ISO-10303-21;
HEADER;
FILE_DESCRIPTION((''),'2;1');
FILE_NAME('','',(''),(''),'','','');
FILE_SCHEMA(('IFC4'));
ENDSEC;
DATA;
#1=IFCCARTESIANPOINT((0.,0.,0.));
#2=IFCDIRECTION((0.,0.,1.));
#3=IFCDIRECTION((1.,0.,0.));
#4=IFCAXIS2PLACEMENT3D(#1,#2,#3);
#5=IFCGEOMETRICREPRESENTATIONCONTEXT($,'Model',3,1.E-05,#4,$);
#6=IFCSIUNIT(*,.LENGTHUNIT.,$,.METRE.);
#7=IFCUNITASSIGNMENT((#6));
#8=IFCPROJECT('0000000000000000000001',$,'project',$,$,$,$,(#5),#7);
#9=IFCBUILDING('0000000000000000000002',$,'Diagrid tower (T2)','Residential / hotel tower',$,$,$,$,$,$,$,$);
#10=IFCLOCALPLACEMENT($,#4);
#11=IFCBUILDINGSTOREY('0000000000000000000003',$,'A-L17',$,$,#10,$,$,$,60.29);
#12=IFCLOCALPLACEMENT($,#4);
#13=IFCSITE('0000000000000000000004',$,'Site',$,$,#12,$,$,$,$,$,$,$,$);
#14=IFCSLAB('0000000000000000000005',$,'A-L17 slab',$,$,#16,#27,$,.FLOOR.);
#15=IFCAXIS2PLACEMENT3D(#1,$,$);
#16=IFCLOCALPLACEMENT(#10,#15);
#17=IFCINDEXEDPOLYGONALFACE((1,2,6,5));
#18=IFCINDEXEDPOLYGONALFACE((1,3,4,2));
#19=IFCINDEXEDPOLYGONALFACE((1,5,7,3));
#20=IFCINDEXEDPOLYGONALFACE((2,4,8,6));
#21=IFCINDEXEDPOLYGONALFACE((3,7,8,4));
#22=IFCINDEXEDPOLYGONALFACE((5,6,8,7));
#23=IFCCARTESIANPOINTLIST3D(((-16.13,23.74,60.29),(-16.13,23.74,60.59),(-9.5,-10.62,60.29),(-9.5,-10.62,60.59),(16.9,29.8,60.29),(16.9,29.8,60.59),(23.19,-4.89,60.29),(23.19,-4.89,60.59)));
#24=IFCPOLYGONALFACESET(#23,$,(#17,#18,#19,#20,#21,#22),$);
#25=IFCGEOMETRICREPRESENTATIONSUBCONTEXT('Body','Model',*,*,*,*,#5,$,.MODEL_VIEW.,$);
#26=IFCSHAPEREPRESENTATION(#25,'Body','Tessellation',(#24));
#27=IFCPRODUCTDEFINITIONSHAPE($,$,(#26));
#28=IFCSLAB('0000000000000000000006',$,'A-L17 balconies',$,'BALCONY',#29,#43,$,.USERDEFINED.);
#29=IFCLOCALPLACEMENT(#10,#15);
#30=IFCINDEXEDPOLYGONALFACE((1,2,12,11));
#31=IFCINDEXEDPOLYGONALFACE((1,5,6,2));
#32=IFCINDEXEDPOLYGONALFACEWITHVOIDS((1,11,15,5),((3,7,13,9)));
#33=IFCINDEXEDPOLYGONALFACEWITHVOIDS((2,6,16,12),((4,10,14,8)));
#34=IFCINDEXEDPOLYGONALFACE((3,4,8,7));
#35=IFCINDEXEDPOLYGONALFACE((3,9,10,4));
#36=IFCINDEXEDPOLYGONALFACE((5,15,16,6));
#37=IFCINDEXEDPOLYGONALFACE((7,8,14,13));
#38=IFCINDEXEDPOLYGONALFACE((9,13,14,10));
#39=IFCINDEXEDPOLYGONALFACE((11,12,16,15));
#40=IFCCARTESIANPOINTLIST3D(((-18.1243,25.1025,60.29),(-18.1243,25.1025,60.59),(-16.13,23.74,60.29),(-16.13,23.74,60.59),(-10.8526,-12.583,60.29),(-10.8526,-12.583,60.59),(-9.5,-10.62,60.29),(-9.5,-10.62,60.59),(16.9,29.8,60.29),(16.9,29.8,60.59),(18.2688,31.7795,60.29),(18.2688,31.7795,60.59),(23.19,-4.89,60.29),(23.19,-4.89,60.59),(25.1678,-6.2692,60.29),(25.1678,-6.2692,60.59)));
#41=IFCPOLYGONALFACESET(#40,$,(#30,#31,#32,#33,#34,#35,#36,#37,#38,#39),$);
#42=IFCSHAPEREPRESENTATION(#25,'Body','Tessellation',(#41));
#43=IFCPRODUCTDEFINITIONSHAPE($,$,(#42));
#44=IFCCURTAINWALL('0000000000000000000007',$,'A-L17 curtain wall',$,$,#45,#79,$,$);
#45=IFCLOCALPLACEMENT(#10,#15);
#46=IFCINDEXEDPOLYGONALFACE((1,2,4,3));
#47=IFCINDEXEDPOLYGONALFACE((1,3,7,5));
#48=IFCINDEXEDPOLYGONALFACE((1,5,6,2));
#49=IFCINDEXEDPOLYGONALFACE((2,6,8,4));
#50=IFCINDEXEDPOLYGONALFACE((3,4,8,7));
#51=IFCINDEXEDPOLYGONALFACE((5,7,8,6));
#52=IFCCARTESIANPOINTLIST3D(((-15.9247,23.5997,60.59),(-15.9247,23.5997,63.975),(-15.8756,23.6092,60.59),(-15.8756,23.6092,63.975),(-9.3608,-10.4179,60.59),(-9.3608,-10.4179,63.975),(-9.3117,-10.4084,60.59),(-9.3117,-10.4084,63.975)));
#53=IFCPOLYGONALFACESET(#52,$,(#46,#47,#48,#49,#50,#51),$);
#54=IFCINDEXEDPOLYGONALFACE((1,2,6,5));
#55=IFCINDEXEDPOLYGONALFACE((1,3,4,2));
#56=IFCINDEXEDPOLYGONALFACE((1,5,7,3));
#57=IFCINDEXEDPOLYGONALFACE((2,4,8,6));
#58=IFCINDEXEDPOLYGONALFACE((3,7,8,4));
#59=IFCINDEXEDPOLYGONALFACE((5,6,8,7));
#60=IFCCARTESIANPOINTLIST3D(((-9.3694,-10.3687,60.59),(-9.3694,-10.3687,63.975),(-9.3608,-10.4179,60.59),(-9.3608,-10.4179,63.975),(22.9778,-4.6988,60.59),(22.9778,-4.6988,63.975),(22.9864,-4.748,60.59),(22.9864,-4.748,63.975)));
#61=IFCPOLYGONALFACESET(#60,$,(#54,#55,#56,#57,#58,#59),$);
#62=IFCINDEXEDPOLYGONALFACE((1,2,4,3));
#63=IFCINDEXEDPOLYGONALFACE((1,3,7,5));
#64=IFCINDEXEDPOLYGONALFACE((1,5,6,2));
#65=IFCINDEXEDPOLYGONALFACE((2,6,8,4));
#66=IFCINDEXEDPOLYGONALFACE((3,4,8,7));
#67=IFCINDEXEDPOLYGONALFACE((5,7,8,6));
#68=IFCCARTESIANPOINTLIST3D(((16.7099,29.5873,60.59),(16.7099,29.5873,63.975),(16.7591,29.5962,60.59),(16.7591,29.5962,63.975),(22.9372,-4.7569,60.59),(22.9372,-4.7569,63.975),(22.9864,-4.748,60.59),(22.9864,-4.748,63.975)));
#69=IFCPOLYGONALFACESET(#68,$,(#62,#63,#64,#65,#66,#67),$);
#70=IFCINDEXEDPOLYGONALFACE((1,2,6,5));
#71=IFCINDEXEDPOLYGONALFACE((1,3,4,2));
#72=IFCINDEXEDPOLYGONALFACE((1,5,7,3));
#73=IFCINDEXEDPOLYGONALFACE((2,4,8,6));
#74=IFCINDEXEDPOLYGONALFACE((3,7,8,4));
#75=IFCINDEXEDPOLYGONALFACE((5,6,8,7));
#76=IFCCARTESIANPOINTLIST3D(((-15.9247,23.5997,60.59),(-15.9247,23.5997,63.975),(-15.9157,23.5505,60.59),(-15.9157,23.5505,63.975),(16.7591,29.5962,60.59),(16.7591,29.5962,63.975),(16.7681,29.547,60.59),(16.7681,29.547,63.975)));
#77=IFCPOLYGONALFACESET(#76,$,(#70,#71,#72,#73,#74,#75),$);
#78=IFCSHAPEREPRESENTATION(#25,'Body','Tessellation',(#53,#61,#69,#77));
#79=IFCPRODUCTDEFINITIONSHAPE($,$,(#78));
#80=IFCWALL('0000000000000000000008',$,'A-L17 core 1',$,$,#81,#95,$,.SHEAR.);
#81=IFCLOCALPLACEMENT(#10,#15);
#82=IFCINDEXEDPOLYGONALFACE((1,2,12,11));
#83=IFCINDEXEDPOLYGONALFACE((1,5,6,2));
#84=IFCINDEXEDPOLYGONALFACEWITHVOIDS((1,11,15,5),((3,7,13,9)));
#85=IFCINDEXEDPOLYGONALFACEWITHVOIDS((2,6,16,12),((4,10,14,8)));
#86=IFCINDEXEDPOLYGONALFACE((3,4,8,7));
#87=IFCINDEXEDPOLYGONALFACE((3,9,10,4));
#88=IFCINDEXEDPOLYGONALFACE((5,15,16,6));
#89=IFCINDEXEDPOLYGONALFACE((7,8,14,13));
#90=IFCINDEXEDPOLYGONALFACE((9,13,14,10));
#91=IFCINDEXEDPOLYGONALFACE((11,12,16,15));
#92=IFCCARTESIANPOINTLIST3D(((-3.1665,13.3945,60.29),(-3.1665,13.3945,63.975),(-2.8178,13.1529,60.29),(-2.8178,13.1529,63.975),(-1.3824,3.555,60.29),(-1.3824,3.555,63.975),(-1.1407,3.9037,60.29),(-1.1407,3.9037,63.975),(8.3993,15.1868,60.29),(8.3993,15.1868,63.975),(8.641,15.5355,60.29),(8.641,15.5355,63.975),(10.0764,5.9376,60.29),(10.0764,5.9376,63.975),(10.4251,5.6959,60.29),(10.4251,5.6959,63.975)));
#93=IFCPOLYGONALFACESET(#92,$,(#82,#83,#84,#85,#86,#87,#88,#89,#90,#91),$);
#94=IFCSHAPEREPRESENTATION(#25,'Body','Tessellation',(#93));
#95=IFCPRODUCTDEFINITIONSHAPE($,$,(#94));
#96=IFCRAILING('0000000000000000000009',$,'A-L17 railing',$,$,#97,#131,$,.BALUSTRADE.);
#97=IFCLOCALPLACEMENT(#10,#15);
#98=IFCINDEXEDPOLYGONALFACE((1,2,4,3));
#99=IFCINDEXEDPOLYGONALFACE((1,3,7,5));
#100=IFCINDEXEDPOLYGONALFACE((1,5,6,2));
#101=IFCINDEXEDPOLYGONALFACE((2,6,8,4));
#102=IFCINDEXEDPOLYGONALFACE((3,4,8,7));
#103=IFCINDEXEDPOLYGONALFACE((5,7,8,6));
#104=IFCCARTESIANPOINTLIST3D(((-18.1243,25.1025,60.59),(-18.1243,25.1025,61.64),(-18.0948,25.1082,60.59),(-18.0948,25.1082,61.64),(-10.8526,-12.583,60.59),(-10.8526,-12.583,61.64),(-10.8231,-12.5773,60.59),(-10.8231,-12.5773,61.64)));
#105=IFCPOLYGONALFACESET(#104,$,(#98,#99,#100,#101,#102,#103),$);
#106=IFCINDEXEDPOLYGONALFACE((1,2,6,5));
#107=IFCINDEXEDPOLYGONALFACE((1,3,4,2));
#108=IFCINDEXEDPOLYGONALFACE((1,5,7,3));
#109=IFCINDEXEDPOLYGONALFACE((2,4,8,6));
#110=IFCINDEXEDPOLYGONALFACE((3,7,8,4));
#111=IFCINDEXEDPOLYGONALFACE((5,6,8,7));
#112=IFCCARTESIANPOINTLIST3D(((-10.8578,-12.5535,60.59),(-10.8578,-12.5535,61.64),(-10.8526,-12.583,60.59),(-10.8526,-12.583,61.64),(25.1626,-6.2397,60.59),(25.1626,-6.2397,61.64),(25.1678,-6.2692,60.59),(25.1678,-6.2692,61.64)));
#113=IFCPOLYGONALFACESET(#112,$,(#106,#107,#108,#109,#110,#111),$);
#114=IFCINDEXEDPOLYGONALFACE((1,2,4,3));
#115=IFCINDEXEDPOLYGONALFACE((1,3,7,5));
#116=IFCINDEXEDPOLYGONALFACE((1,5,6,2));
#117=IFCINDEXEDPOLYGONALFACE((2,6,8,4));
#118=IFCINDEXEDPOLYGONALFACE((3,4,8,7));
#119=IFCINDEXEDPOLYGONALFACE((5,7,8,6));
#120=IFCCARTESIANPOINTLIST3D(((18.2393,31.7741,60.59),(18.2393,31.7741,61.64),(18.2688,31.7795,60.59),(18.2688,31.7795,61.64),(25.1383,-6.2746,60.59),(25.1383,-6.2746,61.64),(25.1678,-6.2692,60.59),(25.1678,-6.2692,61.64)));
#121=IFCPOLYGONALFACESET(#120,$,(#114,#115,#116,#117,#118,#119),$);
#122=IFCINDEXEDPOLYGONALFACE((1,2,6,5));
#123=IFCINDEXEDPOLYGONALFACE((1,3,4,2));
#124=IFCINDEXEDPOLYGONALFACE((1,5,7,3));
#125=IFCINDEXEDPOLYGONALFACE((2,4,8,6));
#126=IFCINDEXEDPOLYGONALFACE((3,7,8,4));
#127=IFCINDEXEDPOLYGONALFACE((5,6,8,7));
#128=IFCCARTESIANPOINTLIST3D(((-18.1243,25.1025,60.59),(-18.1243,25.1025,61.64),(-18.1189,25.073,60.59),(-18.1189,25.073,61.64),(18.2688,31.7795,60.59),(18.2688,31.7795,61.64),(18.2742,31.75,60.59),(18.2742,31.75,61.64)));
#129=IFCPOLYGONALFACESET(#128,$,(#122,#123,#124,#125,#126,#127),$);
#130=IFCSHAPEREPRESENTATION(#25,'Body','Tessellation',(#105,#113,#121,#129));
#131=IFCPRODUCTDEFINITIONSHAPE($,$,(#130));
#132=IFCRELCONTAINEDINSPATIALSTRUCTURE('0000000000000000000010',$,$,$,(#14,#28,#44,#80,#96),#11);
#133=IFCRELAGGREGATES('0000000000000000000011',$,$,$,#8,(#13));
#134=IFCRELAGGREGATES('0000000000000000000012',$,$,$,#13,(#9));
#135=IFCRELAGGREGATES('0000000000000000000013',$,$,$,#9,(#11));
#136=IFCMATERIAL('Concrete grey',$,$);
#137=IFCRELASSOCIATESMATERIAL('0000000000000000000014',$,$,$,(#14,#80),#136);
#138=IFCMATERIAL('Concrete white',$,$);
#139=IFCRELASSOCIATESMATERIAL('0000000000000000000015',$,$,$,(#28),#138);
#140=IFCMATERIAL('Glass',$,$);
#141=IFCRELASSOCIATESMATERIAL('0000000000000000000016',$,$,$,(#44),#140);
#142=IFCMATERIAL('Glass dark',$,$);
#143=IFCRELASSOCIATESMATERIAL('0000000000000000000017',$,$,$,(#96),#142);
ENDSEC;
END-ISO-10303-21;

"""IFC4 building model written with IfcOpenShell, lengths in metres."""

from ifc_helpers import new_model, si_unit, frame, origin_with_axes, place, context, subcontext, project, spatial, polyline, outline, extrude, material, element, save


model = new_model("IFC4")

# Units and contexts
model_context = context("Model", 3, precision=1e-05, world=origin_with_axes())
body_context = subcontext(model_context, "Body", "Model", "MODEL_VIEW")
ifc_project = project(units=[si_unit("LENGTHUNIT", "METRE")], contexts=[model_context])

# Site, building, storey
site_placement = place(None, origin_with_axes())
site = spatial("IfcSite", under=ifc_project, at=site_placement, Name="Site")
building = spatial("IfcBuilding", under=site, Name="Diagrid tower (T2)", Description="Residential / hotel tower")
storey_placement = place(None, origin_with_axes())
storey = spatial("IfcBuildingStorey", under=building, at=storey_placement, Name="A-L17", Elevation=60.29)

# Slabs
ifc_material_1 = material(Name="Concrete grey")
slab_1_placement = place(storey_placement, origin_with_axes())
element("IfcSlab", 1, at=slab_1_placement, inside=storey, material=ifc_material_1, Name="A-L17 slab", PredefinedType="FLOOR", context=body_context, shape_type="SweptSolid", body=[
    extrude(outline(polyline([(-16.13, 23.74), (-9.5, -10.62), (23.19, -4.89), (16.9, 29.8), (-16.13, 23.74)])), frame((0.0, 0.0, 60.29), z_axis=(0.0, 0.0, 1.0), x_axis=(1.0, 0.0, 0.0)), (0.0, 0.0, 1.0), 0.3),
])
ifc_material_2 = material(Name="Concrete white")
slab_2_placement = place(storey_placement, origin_with_axes())
element("IfcSlab", 2, at=slab_2_placement, inside=storey, material=ifc_material_2, Name="A-L17 balconies", ObjectType="BALCONY", PredefinedType="USERDEFINED", context=body_context, shape_type="SweptSolid", body=[
    extrude(outline(polyline([(-18.1243, 25.1025), (-10.8526, -12.583), (25.1678, -6.2692), (18.2688, 31.7795), (-18.1243, 25.1025)]), holes=[polyline([(-16.13, 23.74), (-9.5, -10.62), (23.19, -4.89), (16.9, 29.8), (-16.13, 23.74)])]), frame((0.0, 0.0, 60.29), z_axis=(0.0, 0.0, 1.0), x_axis=(1.0, 0.0, 0.0)), (0.0, 0.0, 1.0), 0.3),
])

# Curtain wall
ifc_material_3 = material(Name="Glass")
curtain_wall_placement = place(storey_placement, origin_with_axes())
element("IfcCurtainWall", 3, at=curtain_wall_placement, inside=storey, material=ifc_material_3, Name="A-L17 curtain wall", context=body_context, shape_type="SweptSolid", body=[
    extrude(outline(polyline([(-15.9247, 23.5997), (-9.3608, -10.4179), (-9.3117, -10.4084), (-15.8756, 23.6092), (-15.9247, 23.5997)])), frame((0.0, 0.0, 60.59), z_axis=(0.0, 0.0, 1.0), x_axis=(1.0, 0.0, 0.0)), (0.0, 0.0, 1.0), 3.385),
    extrude(outline(polyline([(-9.3608, -10.4179), (22.9864, -4.748), (22.9778, -4.6988), (-9.3694, -10.3687), (-9.3608, -10.4179)])), frame((0.0, 0.0, 60.59), z_axis=(0.0, 0.0, 1.0), x_axis=(1.0, 0.0, 0.0)), (0.0, 0.0, 1.0), 3.385),
    extrude(outline(polyline([(22.9864, -4.748), (16.7591, 29.5962), (16.7099, 29.5873), (22.9372, -4.7569), (22.9864, -4.748)])), frame((0.0, 0.0, 60.59), z_axis=(0.0, 0.0, 1.0), x_axis=(1.0, 0.0, 0.0)), (0.0, 0.0, 1.0), 3.385),
    extrude(outline(polyline([(16.7591, 29.5962), (-15.9247, 23.5997), (-15.9157, 23.5505), (16.7681, 29.547), (16.7591, 29.5962)])), frame((0.0, 0.0, 60.59), z_axis=(0.0, 0.0, 1.0), x_axis=(1.0, 0.0, 0.0)), (0.0, 0.0, 1.0), 3.385),
])

# Wall
wall_placement = place(storey_placement, origin_with_axes())
element("IfcWall", 4, at=wall_placement, inside=storey, material=ifc_material_1, Name="A-L17 core 1", PredefinedType="SHEAR", context=body_context, shape_type="SweptSolid", body=[
    extrude(outline(polyline([(10.4251, 5.6959), (8.641, 15.5355), (-3.1665, 13.3945), (-1.3824, 3.555), (10.4251, 5.6959)]), holes=[polyline([(10.0764, 5.9376), (8.3993, 15.1868), (-2.8178, 13.1529), (-1.1407, 3.9037), (10.0764, 5.9376)])]), frame((0.0, 0.0, 60.29), z_axis=(0.0, 0.0, 1.0), x_axis=(1.0, 0.0, 0.0)), (0.0, 0.0, 1.0), 3.685),
])

# Railing
ifc_material_4 = material(Name="Glass dark")
railing_placement = place(storey_placement, origin_with_axes())
element("IfcRailing", 5, at=railing_placement, inside=storey, material=ifc_material_4, Name="A-L17 railing", PredefinedType="BALUSTRADE", context=body_context, shape_type="SweptSolid", body=[
    extrude(outline(polyline([(-18.1243, 25.1025), (-10.8526, -12.583), (-10.8231, -12.5773), (-18.0948, 25.1082), (-18.1243, 25.1025)])), frame((0.0, 0.0, 60.59), z_axis=(0.0, 0.0, 1.0), x_axis=(1.0, 0.0, 0.0)), (0.0, 0.0, 1.0), 1.05),
    extrude(outline(polyline([(-10.8526, -12.583), (25.1678, -6.2692), (25.1626, -6.2397), (-10.8578, -12.5535), (-10.8526, -12.583)])), frame((0.0, 0.0, 60.59), z_axis=(0.0, 0.0, 1.0), x_axis=(1.0, 0.0, 0.0)), (0.0, 0.0, 1.0), 1.05),
    extrude(outline(polyline([(25.1678, -6.2692), (18.2688, 31.7795), (18.2393, 31.7741), (25.1383, -6.2746), (25.1678, -6.2692)])), frame((0.0, 0.0, 60.59), z_axis=(0.0, 0.0, 1.0), x_axis=(1.0, 0.0, 0.0)), (0.0, 0.0, 1.0), 1.05),
    extrude(outline(polyline([(18.2688, 31.7795), (-18.1243, 25.1025), (-18.1189, 25.073), (18.2742, 31.75), (18.2688, 31.7795)])), frame((0.0, 0.0, 60.59), z_axis=(0.0, 0.0, 1.0), x_axis=(1.0, 0.0, 0.0)), (0.0, 0.0, 1.0), 1.05),
])

save(model, "model.ifc")
